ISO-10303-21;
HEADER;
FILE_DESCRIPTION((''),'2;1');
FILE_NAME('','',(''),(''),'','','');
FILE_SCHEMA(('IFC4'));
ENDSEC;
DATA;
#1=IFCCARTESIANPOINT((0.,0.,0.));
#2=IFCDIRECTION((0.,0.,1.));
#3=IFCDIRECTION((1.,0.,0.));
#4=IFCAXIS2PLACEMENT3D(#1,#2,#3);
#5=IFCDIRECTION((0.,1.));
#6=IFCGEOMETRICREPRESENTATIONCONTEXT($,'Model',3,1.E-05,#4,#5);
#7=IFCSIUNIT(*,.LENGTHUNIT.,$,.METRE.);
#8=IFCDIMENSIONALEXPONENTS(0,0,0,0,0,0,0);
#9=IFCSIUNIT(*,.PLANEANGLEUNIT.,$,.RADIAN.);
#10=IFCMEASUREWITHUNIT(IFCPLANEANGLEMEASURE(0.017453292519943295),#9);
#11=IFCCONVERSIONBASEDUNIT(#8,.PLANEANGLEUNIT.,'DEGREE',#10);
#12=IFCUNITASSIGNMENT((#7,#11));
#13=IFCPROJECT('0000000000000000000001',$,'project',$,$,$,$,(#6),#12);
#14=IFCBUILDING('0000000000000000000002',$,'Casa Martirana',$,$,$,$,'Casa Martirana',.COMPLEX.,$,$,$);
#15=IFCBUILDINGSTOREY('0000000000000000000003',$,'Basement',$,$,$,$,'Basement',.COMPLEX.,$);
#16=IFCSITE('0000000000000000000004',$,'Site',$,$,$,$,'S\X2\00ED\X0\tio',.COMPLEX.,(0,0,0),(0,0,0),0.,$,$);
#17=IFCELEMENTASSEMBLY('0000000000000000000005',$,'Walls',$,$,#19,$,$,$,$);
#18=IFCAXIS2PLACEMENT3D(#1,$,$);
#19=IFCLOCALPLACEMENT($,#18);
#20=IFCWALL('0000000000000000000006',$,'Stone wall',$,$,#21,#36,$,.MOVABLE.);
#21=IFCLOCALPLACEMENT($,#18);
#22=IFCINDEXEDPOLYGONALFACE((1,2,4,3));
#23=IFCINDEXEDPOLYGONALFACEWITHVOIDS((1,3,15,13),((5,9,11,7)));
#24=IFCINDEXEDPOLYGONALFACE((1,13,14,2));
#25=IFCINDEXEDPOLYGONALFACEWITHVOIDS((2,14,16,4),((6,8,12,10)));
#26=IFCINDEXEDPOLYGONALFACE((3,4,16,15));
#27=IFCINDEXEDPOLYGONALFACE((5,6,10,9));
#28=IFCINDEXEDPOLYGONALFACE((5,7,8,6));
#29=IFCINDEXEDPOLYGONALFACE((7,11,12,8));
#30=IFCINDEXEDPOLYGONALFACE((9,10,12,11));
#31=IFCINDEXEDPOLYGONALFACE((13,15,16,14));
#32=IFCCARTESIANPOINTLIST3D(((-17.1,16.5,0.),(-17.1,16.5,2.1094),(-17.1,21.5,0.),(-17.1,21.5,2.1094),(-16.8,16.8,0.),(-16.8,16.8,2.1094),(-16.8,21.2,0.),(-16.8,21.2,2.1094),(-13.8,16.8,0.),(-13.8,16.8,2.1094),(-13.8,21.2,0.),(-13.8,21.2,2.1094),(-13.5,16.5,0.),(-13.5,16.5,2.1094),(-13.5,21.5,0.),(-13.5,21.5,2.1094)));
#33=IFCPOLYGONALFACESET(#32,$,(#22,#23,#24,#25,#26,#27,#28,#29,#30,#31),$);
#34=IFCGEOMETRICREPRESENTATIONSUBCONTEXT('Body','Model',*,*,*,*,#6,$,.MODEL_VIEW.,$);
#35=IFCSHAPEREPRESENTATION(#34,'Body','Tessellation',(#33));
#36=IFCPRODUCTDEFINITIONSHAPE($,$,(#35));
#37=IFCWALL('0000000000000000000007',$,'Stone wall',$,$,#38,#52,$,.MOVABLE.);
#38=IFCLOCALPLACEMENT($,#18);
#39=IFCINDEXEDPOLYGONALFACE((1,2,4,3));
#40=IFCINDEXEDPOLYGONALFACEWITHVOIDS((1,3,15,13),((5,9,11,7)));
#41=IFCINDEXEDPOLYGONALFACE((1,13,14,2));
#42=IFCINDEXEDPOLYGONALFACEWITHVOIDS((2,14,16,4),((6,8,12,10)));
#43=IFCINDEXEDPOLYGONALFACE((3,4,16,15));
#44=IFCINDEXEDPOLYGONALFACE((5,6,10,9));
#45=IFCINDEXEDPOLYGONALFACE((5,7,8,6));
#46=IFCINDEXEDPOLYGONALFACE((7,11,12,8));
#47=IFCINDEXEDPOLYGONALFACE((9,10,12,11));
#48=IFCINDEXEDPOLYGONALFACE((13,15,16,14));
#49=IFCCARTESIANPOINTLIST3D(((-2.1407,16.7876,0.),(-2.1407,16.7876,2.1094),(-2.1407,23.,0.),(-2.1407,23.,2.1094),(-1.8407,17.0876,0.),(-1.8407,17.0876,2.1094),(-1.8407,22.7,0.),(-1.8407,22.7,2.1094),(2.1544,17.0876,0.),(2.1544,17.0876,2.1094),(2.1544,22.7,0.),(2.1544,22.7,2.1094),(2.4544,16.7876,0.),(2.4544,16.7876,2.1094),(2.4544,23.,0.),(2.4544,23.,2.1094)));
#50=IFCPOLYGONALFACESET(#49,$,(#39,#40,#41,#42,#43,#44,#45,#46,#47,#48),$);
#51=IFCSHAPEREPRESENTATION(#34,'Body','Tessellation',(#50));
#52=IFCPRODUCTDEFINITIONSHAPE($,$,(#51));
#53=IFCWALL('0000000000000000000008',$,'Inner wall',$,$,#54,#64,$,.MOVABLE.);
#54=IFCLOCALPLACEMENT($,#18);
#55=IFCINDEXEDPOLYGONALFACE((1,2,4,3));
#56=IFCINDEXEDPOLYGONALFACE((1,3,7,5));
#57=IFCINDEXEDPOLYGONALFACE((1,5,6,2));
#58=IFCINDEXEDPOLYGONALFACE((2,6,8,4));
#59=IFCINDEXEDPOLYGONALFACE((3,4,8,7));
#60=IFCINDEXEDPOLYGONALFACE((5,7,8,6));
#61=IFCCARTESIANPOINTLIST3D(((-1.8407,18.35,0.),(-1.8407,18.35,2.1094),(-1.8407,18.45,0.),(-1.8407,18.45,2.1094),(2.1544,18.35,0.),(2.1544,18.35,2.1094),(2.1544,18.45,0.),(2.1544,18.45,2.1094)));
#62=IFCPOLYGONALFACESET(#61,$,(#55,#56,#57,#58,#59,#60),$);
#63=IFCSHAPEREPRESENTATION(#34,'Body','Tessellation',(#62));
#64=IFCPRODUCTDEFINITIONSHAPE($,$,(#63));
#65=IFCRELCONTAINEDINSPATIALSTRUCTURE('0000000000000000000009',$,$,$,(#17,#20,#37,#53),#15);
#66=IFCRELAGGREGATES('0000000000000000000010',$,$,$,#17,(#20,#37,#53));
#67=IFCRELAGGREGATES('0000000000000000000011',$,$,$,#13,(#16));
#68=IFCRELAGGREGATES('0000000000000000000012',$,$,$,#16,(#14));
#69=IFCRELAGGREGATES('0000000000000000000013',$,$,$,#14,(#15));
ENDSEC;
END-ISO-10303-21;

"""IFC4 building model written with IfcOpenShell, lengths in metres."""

from ifc_helpers import new_model, entity, si_unit, converted_unit, direction, frame, origin_with_axes, origin_2d_with_axis, place, context, subcontext, project, spatial, polyline, rectangle, outline, extrude, element, aggregate, save


model = new_model("IFC4")

# Units and contexts
model_context = context("Model", 3, precision=1e-05, world=origin_with_axes(), true_north=direction((0.0, 1.0)))
body_context = subcontext(model_context, "Body", "Model", "MODEL_VIEW")
ifc_project = project(units=[si_unit("LENGTHUNIT", "METRE"), converted_unit("PLANEANGLEUNIT", "DEGREE", entity("IfcPlaneAngleMeasure", 0.017453292519943295), si_unit("PLANEANGLEUNIT", "RADIAN"), dimensions=[0, 0, 0, 0, 0, 0, 0])], contexts=[model_context])

# Site, building, storey
site = spatial("IfcSite", under=ifc_project, Name="Site", LongName="Sítio", CompositionType="COMPLEX", RefLatitude=(0, 0, 0), RefLongitude=(0, 0, 0), RefElevation=0.0)
building = spatial("IfcBuilding", under=site, Name="Casa Martirana", LongName="Casa Martirana", CompositionType="COMPLEX")
storey = spatial("IfcBuildingStorey", under=building, Name="Basement", LongName="Basement", CompositionType="COMPLEX")

# Shared definitions
placement = place(None, origin_with_axes())

# Element assembly, walls
assembly_1 = element("IfcElementAssembly", 1, inside=storey, Name="Walls")
wall_1 = element("IfcWall", 2, at=placement, inside=storey, Name="Stone wall", PredefinedType="MOVABLE", context=body_context, shape_type="SweptSolid", body=[
    extrude(outline(polyline([(-1.8, -2.5), (1.8, -2.5), (1.8, 2.5), (-1.8, 2.5), (-1.8, -2.5)]), holes=[polyline([(1.5, 2.2), (-1.5, 2.2), (-1.5, -2.2), (1.5, -2.2), (1.5, 2.2)])]), frame((-15.3, 19.0, 0.0), z_axis=(0.0, 0.0, 1.0), x_axis=(1.0, 0.0, 0.0)), (0.0, 0.0, 1.0), 2.1094),
])
wall_2 = element("IfcWall", 3, at=placement, inside=storey, Name="Stone wall", PredefinedType="MOVABLE", context=body_context, shape_type="SweptSolid", body=[
    extrude(outline(polyline([(-2.2975, -3.1062), (2.2975, -3.1062), (2.2975, 3.1062), (-2.2975, 3.1062), (-2.2975, -3.1062)]), holes=[polyline([(1.9975, 2.8062), (-1.9975, 2.8062), (-1.9975, -2.8062), (1.9975, -2.8062), (1.9975, 2.8062)])]), frame((0.1569, 19.8938, 0.0), z_axis=(0.0, 0.0, 1.0), x_axis=(1.0, 0.0, 0.0)), (0.0, 0.0, 1.0), 2.1094),
])
wall_3 = element("IfcWall", 4, at=placement, inside=storey, Name="Inner wall", PredefinedType="MOVABLE", context=body_context, shape_type="SweptSolid", body=[
    extrude(rectangle(XDim=3.9951, YDim=0.1, at=origin_2d_with_axis()), frame((0.1569, 18.4, 0.0), z_axis=(0.0, 0.0, 1.0), x_axis=(1.0, 0.0, 0.0)), (0.0, 0.0, 1.0), 2.1094),
])
aggregate(assembly_1, [wall_1, wall_2, wall_3])

save(model, "model.ifc")
